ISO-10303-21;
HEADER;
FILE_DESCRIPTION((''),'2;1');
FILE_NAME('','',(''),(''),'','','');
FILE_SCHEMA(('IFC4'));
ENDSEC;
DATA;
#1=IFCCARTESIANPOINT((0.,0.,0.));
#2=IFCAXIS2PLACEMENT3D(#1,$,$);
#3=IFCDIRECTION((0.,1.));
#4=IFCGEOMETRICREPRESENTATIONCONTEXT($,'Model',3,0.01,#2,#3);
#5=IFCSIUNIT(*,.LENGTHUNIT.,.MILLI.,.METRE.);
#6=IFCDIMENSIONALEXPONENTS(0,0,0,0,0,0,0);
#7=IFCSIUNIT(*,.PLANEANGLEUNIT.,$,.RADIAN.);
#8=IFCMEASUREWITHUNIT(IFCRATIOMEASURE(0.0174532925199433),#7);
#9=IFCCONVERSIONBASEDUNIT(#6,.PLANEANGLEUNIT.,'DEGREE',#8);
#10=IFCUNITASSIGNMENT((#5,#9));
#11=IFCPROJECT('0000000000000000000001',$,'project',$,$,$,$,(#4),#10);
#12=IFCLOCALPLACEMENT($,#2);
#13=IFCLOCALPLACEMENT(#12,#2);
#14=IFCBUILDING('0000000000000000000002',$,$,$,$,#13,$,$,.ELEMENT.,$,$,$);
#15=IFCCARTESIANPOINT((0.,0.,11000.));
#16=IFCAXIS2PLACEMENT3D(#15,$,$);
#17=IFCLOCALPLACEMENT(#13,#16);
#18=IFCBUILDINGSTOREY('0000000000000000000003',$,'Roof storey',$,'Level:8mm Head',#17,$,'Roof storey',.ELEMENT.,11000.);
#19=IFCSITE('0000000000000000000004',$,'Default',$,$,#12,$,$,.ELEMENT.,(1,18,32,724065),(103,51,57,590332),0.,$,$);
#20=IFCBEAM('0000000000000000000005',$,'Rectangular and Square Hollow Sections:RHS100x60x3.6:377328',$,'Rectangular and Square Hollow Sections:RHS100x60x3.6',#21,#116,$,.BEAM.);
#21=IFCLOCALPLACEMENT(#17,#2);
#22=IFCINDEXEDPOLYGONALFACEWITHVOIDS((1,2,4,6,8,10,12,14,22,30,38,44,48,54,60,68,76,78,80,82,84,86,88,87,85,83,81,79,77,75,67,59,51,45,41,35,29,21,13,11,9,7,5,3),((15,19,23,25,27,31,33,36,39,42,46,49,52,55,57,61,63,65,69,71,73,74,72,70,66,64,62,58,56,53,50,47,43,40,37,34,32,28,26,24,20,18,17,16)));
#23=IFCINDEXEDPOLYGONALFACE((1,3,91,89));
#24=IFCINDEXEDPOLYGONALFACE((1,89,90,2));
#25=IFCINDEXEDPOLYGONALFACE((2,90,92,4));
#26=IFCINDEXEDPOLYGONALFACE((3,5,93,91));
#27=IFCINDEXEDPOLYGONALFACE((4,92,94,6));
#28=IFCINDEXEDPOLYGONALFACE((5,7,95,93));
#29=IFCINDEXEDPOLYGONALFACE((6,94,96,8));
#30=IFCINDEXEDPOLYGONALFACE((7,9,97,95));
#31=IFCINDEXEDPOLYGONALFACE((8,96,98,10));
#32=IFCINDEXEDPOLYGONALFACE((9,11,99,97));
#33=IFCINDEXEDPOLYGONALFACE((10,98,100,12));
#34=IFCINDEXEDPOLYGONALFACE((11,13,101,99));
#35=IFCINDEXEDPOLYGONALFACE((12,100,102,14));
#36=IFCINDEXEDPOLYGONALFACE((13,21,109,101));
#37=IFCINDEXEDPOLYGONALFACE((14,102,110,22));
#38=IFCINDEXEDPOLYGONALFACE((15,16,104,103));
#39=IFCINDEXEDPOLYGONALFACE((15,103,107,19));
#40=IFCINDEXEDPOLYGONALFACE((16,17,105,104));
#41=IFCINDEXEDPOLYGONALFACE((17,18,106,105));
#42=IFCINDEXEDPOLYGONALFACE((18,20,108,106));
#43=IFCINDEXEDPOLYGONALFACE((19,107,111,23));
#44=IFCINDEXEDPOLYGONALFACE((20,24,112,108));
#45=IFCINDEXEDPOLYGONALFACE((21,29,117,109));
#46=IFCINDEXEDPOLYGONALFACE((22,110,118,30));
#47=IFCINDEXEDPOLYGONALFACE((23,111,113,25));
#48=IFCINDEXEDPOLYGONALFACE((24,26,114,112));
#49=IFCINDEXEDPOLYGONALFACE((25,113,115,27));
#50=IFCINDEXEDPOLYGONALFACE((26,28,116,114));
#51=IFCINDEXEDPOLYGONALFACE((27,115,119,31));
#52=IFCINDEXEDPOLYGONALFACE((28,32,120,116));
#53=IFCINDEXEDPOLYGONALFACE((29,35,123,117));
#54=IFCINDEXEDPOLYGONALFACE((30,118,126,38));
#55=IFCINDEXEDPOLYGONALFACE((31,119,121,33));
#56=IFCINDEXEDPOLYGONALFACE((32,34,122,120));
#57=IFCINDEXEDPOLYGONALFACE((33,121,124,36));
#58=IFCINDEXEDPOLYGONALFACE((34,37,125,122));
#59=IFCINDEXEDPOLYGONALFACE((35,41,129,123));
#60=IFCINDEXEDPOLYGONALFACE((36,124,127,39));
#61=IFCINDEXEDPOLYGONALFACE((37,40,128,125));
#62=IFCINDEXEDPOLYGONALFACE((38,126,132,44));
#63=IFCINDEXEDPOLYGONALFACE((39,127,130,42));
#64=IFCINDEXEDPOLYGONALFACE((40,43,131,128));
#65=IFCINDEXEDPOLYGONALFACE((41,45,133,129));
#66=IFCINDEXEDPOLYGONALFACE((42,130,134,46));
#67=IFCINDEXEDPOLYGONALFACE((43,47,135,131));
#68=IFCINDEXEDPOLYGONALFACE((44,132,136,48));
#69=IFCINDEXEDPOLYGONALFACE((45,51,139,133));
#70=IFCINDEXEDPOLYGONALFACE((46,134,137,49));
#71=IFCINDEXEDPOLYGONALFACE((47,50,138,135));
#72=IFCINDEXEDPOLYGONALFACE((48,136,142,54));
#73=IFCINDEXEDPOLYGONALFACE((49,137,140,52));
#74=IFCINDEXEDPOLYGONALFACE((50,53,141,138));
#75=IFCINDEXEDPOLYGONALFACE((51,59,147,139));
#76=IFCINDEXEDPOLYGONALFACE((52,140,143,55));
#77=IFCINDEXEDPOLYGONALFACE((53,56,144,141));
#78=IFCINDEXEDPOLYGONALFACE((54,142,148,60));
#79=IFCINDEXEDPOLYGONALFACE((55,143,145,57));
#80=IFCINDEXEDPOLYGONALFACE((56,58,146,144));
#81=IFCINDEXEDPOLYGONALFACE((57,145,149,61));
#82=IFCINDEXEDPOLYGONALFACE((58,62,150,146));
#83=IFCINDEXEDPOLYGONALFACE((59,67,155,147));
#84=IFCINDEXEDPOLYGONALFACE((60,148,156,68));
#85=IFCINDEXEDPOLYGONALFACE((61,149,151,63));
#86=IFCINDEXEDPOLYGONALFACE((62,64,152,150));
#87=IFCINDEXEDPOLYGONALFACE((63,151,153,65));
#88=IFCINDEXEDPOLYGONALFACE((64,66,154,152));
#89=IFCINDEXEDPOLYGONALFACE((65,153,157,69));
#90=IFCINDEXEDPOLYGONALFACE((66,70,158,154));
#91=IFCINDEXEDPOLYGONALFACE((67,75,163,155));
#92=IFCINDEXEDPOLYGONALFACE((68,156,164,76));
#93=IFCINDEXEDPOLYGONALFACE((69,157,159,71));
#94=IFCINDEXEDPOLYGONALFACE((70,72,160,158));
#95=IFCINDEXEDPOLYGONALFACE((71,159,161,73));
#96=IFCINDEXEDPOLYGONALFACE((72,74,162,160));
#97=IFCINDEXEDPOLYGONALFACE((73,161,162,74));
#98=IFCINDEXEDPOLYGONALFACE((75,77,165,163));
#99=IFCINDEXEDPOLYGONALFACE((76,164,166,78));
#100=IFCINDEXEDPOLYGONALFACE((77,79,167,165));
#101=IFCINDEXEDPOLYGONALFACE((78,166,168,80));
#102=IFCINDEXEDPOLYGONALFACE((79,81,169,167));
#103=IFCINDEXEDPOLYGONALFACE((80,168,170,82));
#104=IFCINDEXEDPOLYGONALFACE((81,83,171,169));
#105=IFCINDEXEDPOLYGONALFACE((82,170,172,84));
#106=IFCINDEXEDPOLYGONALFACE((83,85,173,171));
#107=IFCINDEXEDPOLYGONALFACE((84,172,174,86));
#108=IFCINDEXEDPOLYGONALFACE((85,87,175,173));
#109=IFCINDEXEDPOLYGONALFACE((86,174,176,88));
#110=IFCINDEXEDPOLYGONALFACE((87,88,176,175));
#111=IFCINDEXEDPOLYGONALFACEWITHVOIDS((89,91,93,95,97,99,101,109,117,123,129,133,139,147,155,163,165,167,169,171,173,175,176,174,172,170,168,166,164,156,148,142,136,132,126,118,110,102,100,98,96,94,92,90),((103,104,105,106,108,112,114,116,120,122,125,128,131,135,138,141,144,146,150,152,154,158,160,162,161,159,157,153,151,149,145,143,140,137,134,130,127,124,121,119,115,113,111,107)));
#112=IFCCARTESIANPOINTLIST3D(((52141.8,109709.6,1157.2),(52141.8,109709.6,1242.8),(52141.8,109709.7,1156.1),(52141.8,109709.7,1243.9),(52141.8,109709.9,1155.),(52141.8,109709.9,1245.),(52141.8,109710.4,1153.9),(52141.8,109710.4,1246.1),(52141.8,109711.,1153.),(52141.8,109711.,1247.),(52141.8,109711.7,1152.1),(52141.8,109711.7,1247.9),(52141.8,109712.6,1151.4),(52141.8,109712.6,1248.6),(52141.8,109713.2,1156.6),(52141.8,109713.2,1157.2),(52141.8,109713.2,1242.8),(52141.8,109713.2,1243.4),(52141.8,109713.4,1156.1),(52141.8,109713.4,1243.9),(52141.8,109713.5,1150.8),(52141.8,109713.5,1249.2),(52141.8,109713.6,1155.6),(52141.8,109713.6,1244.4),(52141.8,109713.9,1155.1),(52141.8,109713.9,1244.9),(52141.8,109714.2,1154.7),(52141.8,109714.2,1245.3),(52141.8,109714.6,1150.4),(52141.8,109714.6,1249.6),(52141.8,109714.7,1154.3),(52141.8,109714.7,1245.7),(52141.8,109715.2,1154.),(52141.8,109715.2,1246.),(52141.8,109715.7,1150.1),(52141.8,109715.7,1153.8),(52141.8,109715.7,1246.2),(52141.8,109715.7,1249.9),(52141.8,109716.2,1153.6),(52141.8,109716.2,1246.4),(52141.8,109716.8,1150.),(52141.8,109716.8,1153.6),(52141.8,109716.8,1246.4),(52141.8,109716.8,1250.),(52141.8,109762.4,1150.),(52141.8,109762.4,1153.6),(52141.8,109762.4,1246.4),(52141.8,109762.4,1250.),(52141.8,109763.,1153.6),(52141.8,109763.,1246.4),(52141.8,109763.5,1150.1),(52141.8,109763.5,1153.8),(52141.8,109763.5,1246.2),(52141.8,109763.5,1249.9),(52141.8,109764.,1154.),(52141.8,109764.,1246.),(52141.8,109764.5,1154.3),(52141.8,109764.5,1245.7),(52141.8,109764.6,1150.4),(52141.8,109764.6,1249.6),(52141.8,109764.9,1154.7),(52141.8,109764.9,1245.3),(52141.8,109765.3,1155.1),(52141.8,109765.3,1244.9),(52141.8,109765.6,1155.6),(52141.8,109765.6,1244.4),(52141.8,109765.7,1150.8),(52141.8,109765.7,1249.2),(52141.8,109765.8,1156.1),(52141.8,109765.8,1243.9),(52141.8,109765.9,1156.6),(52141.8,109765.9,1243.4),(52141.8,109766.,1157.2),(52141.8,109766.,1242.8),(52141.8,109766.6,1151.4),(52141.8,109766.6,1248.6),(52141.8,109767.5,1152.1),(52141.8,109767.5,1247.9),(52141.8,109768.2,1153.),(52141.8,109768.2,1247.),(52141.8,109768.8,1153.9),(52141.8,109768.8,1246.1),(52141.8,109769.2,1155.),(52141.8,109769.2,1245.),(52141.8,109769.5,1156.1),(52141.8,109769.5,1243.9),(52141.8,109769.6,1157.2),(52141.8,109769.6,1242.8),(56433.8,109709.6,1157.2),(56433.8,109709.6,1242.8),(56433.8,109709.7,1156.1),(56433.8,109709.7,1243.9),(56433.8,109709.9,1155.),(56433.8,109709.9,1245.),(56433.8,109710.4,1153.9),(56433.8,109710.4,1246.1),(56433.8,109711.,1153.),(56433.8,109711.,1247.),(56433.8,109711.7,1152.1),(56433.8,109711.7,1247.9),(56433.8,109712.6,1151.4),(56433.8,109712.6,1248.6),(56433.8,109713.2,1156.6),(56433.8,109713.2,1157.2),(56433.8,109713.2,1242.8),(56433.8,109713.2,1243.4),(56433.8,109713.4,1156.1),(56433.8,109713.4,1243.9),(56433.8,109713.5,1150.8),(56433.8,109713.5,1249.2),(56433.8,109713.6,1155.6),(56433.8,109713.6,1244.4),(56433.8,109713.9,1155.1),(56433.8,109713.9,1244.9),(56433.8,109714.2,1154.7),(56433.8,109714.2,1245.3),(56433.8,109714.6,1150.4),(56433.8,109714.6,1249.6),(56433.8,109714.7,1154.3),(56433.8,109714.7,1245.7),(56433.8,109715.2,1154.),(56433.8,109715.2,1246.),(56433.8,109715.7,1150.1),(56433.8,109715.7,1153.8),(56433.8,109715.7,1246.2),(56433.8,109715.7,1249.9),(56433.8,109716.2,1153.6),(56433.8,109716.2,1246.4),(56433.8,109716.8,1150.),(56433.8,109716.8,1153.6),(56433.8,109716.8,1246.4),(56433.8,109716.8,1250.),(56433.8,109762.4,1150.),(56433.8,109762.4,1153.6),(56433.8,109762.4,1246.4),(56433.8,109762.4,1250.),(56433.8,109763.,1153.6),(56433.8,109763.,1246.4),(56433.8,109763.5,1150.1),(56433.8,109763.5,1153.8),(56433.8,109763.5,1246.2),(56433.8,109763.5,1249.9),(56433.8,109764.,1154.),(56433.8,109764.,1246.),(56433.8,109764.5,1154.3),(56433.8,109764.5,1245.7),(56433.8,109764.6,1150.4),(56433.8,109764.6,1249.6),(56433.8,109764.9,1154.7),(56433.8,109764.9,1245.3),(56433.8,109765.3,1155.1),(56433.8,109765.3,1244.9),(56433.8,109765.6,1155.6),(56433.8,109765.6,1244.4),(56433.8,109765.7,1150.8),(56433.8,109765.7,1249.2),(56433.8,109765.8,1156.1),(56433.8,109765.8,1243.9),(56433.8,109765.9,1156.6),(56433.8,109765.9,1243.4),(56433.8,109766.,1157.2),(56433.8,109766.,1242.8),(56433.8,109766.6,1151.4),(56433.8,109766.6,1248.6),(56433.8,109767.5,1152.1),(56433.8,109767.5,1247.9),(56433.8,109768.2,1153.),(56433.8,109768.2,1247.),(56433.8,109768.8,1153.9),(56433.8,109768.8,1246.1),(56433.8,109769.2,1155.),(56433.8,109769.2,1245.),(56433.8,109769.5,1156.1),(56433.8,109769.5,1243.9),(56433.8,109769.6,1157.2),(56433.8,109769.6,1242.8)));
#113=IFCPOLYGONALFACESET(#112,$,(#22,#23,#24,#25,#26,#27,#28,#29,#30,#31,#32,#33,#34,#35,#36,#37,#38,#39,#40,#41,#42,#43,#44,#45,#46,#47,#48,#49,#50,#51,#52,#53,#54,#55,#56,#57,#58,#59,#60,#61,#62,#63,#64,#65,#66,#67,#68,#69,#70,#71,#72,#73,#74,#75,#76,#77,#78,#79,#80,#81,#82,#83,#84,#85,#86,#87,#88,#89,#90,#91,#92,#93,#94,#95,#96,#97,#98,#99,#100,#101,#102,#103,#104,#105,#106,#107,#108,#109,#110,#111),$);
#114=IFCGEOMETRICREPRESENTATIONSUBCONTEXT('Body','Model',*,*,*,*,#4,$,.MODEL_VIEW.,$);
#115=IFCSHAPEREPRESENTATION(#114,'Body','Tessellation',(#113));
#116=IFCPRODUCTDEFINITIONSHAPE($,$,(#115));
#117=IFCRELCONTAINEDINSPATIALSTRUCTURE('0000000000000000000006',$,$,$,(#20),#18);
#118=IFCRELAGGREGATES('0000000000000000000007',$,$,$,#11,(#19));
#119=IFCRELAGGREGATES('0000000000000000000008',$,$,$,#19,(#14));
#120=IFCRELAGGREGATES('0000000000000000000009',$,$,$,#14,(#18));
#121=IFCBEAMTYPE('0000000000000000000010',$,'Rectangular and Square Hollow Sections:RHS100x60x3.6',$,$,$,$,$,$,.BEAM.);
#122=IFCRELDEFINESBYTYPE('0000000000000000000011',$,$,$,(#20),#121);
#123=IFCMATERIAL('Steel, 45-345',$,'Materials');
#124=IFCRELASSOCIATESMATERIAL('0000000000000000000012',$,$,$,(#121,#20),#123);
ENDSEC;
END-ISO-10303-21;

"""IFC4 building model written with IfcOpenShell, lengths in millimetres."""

from ifc_helpers import new_model, entity, si_unit, converted_unit, direction, frame, origin, place, context, subcontext, project, spatial, indexed_curve, outline, extrude, source, transform, mapped, material, type_object, type_shapes, element, save


model = new_model("IFC4")

# Units and contexts
model_context = context("Model", 3, precision=0.01, world=origin(), true_north=direction((0.0, 1.0)))
body_context = subcontext(model_context, "Body", "Model", "MODEL_VIEW")
ifc_project = project(units=[si_unit("LENGTHUNIT", "METRE", prefix="MILLI"), converted_unit("PLANEANGLEUNIT", "DEGREE", entity("IfcRatioMeasure", 0.0174532925199433), si_unit("PLANEANGLEUNIT", "RADIAN"), dimensions=[0, 0, 0, 0, 0, 0, 0])], contexts=[model_context])

# Site, building, storey
site_placement = place(None, origin())
site = spatial("IfcSite", under=ifc_project, at=site_placement, Name="Default", CompositionType="ELEMENT", RefLatitude=(1, 18, 32, 724065), RefLongitude=(103, 51, 57, 590332), RefElevation=0.0)
building_placement = place(site_placement, origin())
building = spatial("IfcBuilding", under=site, at=building_placement, CompositionType="ELEMENT")
storey_placement = place(building_placement, frame((0.0, 0.0, 11000.0)))
storey = spatial("IfcBuildingStorey", under=building, at=storey_placement, Name="Roof storey", ObjectType="Level:8mm Head", LongName="Roof storey", CompositionType="ELEMENT", Elevation=11000.0)

# Shared definitions
ifc_material = material(Name="Steel, 45-345", Category="Materials")

# Beam
beam_type_1 = type_object("IfcBeamType", Name="Rectangular and Square Hollow Sections:RHS100x60x3.6", PredefinedType="BEAM", material=ifc_material)
shared_shape_1 = source(origin(), body_context, "Body", "SweptSolid", [
    extrude(outline(indexed_curve([(-30.0, -42.8), (-29.9, -43.9), (-29.6, -45.0), (-29.2, -46.1), (-28.6, -47.0), (-27.9, -47.9), (-27.0, -48.6), (-26.1, -49.2), (-25.0, -49.6), (-23.9, -49.9), (-22.8, -50.0), (22.8, -50.0), (23.9, -49.9), (25.0, -49.6), (26.1, -49.2), (27.0, -48.6), (27.9, -47.9), (28.6, -47.0), (29.2, -46.1), (29.6, -45.0), (29.9, -43.9), (30.0, -42.8), (30.0, 42.8), (29.9, 43.9), (29.6, 45.0), (29.2, 46.1), (28.6, 47.0), (27.9, 47.9), (27.0, 48.6), (26.1, 49.2), (25.0, 49.6), (23.9, 49.9), (22.8, 50.0), (-22.8, 50.0), (-23.9, 49.9), (-25.0, 49.6), (-26.1, 49.2), (-27.0, 48.6), (-27.9, 47.9), (-28.6, 47.0), (-29.2, 46.1), (-29.6, 45.0), (-29.9, 43.9), (-30.0, 42.8), (-30.0, -42.8)], self_intersect=False), holes=[indexed_curve([(22.8, -46.4), (-22.8, -46.4), (-23.4, -46.4), (-23.9, -46.2), (-24.4, -46.0), (-24.9, -45.7), (-25.3, -45.3), (-25.7, -44.9), (-26.0, -44.4), (-26.2, -43.9), (-26.4, -43.4), (-26.4, -42.8), (-26.4, 42.8), (-26.4, 43.4), (-26.2, 43.9), (-26.0, 44.4), (-25.7, 44.9), (-25.3, 45.3), (-24.9, 45.7), (-24.4, 46.0), (-23.9, 46.2), (-23.4, 46.4), (-22.8, 46.4), (22.8, 46.4), (23.4, 46.4), (23.9, 46.2), (24.4, 46.0), (24.9, 45.7), (25.3, 45.3), (25.7, 44.9), (26.0, 44.4), (26.2, 43.9), (26.4, 43.4), (26.4, 42.8), (26.4, -42.8), (26.4, -43.4), (26.2, -43.9), (26.0, -44.4), (25.7, -44.9), (25.3, -45.3), (24.9, -45.7), (24.4, -46.0), (23.9, -46.2), (23.4, -46.4), (22.8, -46.4)], self_intersect=False)]), frame((-2152.5, 0.0, 0.0), z_axis=(1.0, 0.0, 0.0), x_axis=(0.0, -1.0, 0.0)), (0.0, 0.0, 1.0), 4292.0),
])
type_shapes(beam_type_1, [shared_shape_1])
for number, where, name in (
    (1, (54294.3, 109739.6, 1200.0), "Rectangular and Square Hollow Sections:RHS100x60x3.6:377328"),
):
    element("IfcBeam", number, at=place(storey_placement, frame(where)), inside=storey, type_object=beam_type_1, material=ifc_material, Name=name, ObjectType="Rectangular and Square Hollow Sections:RHS100x60x3.6", PredefinedType="BEAM", context=body_context, shape_type="MappedRepresentation", body=[
        mapped(shared_shape_1, transform((0.0, 0.0, 0.0), scale=1.0)),
    ])

save(model, "model.ifc")
